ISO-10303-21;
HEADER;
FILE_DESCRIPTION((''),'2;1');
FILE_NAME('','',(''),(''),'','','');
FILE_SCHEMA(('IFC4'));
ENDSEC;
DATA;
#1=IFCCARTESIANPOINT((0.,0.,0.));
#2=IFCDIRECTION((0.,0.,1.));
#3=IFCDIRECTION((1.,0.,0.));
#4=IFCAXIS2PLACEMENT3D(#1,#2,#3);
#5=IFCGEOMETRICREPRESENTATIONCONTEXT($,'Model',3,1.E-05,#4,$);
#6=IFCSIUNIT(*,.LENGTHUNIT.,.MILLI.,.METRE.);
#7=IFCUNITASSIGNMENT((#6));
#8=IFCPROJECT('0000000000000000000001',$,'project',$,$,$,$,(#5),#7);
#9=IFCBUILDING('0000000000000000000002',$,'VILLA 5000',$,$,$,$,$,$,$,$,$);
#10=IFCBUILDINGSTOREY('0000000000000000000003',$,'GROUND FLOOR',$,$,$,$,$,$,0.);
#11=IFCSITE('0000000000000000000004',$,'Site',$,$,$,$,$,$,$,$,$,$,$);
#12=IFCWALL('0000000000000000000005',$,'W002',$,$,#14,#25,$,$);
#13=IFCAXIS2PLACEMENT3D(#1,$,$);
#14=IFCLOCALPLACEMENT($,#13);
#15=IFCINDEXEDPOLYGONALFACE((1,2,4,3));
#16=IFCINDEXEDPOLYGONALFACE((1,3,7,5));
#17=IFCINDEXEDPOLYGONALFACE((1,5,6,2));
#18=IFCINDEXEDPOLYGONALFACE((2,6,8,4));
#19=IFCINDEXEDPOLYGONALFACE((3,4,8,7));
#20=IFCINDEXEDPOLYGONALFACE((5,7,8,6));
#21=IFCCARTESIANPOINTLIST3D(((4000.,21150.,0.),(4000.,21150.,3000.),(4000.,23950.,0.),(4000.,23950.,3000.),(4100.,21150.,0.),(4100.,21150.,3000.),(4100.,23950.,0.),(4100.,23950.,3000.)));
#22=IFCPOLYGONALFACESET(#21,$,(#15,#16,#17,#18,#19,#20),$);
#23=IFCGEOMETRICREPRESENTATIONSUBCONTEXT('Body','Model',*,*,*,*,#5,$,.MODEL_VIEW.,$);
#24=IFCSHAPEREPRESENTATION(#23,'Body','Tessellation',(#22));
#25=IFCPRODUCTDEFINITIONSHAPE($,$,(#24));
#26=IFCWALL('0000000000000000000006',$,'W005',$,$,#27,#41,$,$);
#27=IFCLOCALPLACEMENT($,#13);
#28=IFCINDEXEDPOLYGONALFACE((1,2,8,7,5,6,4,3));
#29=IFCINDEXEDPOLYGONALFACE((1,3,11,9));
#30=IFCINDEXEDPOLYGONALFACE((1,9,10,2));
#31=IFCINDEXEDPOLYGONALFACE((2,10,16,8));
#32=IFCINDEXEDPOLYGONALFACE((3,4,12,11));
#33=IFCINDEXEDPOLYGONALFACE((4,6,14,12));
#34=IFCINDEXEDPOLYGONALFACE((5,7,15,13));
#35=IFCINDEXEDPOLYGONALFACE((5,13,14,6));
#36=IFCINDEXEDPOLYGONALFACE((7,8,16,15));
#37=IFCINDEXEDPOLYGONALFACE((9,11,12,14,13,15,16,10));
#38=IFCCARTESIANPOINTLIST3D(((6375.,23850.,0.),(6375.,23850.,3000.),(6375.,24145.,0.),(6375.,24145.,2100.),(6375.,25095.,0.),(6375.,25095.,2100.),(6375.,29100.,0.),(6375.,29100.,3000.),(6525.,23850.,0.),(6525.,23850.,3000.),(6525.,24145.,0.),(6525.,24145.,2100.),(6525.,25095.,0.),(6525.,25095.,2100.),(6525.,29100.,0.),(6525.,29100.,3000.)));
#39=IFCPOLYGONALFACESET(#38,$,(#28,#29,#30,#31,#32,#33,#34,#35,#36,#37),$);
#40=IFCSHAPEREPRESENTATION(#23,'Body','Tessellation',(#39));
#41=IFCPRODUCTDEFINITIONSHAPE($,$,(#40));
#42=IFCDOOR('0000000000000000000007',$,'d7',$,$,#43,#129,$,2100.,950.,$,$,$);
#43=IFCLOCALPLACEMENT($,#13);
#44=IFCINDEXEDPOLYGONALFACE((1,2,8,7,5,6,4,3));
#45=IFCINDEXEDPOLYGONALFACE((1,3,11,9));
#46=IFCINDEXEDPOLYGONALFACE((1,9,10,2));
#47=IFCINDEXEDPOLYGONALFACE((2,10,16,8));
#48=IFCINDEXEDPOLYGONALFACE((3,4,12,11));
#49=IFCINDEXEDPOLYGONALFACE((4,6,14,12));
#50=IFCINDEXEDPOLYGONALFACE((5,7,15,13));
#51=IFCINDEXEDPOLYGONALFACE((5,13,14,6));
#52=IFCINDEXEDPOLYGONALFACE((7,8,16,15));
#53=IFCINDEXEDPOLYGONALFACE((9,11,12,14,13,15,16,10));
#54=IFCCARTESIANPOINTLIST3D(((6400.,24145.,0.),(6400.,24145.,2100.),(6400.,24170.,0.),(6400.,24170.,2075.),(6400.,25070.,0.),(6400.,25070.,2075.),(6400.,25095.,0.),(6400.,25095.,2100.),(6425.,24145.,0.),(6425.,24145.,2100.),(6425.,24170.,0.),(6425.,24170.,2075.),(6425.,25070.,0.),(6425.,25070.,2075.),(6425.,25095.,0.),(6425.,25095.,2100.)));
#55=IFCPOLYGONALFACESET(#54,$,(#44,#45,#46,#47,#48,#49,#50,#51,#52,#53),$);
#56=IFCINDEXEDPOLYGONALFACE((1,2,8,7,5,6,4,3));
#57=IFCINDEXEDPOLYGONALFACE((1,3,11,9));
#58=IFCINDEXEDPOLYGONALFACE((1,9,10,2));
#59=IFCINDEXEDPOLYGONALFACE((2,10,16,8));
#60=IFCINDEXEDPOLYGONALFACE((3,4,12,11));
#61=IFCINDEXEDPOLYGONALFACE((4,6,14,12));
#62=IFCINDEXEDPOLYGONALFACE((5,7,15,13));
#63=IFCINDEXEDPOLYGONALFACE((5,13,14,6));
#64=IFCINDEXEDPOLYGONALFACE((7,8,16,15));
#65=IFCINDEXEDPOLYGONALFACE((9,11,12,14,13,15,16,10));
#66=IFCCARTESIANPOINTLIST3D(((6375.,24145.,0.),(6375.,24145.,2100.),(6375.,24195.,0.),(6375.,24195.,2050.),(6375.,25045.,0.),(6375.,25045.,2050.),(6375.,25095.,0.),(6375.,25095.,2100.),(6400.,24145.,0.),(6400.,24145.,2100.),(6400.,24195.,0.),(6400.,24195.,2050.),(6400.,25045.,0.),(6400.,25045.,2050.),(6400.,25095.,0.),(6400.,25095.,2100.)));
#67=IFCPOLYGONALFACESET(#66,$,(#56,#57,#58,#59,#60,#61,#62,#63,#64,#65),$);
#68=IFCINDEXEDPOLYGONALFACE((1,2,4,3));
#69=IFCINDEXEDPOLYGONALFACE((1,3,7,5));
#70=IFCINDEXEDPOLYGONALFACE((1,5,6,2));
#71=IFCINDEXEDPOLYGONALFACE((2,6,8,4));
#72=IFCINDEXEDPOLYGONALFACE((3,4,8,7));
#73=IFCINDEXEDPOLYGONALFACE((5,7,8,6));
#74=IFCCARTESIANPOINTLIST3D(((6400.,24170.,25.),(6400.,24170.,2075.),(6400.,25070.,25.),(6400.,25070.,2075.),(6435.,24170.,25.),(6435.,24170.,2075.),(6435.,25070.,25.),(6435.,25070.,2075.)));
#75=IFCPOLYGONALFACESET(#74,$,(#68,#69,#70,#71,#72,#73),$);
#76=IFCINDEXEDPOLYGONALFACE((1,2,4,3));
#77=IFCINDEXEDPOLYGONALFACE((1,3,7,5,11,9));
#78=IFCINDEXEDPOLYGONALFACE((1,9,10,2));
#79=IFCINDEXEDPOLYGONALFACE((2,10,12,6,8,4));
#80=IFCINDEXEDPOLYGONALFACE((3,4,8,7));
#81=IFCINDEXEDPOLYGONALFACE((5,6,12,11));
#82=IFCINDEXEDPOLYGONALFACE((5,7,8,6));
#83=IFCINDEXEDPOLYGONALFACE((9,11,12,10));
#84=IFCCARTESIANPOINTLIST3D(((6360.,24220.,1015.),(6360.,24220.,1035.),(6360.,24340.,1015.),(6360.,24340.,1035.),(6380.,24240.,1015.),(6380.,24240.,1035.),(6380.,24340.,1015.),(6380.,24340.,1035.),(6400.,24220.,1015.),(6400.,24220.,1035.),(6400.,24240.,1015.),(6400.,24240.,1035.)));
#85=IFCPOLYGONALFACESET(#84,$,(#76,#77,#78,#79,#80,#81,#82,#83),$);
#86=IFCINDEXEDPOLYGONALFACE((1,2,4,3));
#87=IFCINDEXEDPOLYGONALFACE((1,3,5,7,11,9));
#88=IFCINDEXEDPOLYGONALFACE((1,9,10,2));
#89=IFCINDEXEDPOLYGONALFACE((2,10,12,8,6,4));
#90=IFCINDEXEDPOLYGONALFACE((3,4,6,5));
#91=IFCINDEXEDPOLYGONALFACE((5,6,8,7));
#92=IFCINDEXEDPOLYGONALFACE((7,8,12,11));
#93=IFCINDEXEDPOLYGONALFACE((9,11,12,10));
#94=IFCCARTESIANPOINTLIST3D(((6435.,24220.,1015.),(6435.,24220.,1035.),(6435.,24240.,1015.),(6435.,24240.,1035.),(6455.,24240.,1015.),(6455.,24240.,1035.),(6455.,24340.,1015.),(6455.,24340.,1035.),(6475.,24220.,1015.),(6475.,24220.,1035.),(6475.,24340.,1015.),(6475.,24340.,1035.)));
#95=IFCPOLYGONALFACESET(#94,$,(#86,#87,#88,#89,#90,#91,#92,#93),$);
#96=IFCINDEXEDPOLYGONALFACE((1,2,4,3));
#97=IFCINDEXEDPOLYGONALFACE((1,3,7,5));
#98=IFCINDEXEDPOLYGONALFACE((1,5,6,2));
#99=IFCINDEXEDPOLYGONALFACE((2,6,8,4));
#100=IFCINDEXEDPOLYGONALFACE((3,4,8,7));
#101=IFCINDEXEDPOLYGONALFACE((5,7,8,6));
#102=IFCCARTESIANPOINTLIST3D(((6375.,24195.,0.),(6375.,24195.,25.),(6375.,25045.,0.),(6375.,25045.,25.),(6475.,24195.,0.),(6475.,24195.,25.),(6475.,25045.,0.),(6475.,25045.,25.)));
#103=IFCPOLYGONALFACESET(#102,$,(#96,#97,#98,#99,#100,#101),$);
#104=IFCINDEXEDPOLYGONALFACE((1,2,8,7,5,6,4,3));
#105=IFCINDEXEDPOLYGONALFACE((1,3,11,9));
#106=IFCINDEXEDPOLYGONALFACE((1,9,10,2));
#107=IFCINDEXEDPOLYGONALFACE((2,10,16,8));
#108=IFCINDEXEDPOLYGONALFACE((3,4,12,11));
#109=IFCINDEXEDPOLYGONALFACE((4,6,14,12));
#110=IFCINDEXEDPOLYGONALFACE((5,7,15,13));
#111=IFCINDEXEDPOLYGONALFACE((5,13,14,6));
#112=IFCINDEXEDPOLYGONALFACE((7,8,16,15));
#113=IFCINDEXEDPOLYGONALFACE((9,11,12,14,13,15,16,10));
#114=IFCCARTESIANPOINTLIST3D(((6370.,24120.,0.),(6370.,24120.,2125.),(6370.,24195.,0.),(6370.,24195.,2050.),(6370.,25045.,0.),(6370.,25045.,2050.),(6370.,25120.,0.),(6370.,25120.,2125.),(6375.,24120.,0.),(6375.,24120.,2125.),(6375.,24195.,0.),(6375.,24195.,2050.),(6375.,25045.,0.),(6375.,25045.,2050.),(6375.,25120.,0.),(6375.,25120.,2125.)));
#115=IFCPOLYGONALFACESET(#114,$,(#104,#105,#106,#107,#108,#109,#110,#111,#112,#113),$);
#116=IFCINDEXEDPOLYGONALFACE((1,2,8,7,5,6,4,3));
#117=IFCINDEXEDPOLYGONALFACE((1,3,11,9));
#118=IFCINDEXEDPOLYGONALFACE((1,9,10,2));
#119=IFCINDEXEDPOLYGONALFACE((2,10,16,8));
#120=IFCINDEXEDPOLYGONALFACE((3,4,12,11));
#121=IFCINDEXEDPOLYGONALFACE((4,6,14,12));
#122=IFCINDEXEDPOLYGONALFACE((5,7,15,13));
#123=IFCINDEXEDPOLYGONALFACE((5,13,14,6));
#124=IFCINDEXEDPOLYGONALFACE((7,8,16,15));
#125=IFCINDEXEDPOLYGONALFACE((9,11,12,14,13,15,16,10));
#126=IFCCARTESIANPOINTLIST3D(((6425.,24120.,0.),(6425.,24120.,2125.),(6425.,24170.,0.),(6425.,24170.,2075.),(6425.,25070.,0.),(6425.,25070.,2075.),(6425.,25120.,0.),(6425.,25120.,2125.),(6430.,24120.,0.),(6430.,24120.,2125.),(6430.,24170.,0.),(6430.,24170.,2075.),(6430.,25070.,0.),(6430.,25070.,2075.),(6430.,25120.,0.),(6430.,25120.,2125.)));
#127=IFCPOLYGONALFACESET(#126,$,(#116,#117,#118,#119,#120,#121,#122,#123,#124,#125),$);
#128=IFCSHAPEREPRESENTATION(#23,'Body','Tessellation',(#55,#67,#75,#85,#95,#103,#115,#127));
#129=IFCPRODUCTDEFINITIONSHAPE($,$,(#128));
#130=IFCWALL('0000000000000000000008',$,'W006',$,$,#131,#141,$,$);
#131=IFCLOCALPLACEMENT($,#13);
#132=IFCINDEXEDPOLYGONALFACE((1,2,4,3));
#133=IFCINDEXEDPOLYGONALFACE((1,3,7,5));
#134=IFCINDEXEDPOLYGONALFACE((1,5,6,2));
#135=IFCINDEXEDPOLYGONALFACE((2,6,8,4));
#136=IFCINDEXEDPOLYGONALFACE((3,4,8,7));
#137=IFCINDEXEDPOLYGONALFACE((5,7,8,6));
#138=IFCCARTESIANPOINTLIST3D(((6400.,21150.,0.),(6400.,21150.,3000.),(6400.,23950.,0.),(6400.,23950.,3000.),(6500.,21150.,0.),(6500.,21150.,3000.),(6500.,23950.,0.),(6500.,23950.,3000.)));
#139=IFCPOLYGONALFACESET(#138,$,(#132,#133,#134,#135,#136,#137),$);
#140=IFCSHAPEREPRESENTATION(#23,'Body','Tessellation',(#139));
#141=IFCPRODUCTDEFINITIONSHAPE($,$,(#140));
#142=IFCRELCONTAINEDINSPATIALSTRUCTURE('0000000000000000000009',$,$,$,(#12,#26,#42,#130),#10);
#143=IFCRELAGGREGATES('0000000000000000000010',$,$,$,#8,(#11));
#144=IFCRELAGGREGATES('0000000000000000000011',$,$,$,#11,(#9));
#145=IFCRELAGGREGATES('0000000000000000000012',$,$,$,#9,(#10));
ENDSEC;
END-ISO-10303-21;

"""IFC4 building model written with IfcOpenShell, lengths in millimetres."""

from ifc_helpers import new_model, si_unit, frame, origin_with_axes, place, context, subcontext, project, spatial, line, indexed_curve, outline, extrude, element, fill, save


model = new_model("IFC4")

# Units and contexts
model_context = context("Model", 3, precision=1e-05, world=origin_with_axes())
body_context = subcontext(model_context, "Body", "Model", "MODEL_VIEW")
ifc_project = project(units=[si_unit("LENGTHUNIT", "METRE", prefix="MILLI")], contexts=[model_context])

# Site, building, storey
site = spatial("IfcSite", under=ifc_project, Name="Site")
building = spatial("IfcBuilding", under=site, Name="VILLA 5000")
storey = spatial("IfcBuildingStorey", under=building, Name="GROUND FLOOR", Elevation=0.0)

# Wall
wall_1_placement = place(None, frame((4050.0, 23950.0, 0.0), z_axis=(0.0, 0.0, 1.0), x_axis=(0.0, -1.0, 0.0)))
element("IfcWall", 1, at=wall_1_placement, inside=storey, Name="W002", context=body_context, shape_type="SweptSolid", body=[
    extrude(outline(indexed_curve([(0.0, 0.0), (0.0, 100.0), (2800.0, 100.0), (2800.0, 0.0), (0.0, 0.0)], self_intersect=False)), frame((0.0, -50.0, 0.0), z_axis=(0.0, 0.0, 1.0), x_axis=(1.0, 0.0, 0.0)), (0.0, 0.0, 1.0), 3000.0),
])

# Wall, opening, door
wall_2_placement = place(None, frame((6450.0, 29100.0, 0.0), z_axis=(0.0, 0.0, 1.0), x_axis=(0.0, -1.0, 0.0)))
wall_2 = element("IfcWall", 2, at=wall_2_placement, inside=storey, Name="W005", context=body_context, shape_type="SweptSolid", body=[
    extrude(outline(indexed_curve([(0.0, 0.0), (0.0, 150.0), (5250.0, 150.0), (5250.0, 0.0), (0.0, 0.0)], self_intersect=False)), frame((0.0, -75.0, 0.0), z_axis=(0.0, 0.0, 1.0), x_axis=(1.0, 0.0, 0.0)), (0.0, 0.0, 1.0), 3000.0),
])
opening_1_placement = place(wall_2_placement, frame((4005.0, 0.0, 0.0), z_axis=(0.0, 0.0, 1.0), x_axis=(1.0, 0.0, 0.0)))
opening_1 = element("IfcOpeningElement", 3, at=opening_1_placement, cuts=wall_2, context=body_context, shape_type="SweptSolid", body=[
    extrude(outline(indexed_curve([(0.0, 0.0), (0.0, 250.0), (950.0, 250.0), (950.0, 0.0), (0.0, 0.0)], self_intersect=False)), frame((0.0, -125.0, 0.0), z_axis=(0.0, 0.0, 1.0), x_axis=(1.0, 0.0, 0.0)), (0.0, 0.0, 1.0), 2100.0),
])
door_1_placement = place(None, frame((6375.0, 25095.0, 0.0), z_axis=(0.0, 0.0, 1.0), x_axis=(0.0, -1.0, 0.0)))
door_1 = element("IfcDoor", 4, at=door_1_placement, inside=storey, Name="d7", OverallHeight=2100.0, OverallWidth=950.0, context=body_context, shape_type="SweptSolid", body=[
    extrude(outline(indexed_curve([(0.0, 0.0), (0.0, 2100.0), (950.0, 2100.0), (950.0, 0.0), (925.0, 0.0), (925.0, 2075.0), (25.0, 2075.0), (25.0, 0.0)], segments=[line(1, 2, 3, 4, 5, 6, 7, 8, 1)])), frame((0.0, 25.0, 0.0), z_axis=(0.0, -1.0, 0.0), x_axis=(1.0, 0.0, 0.0)), (0.0, 0.0, -1.0), 25.0),
    extrude(outline(indexed_curve([(0.0, 0.0), (0.0, 2100.0), (950.0, 2100.0), (950.0, 0.0), (900.0, 0.0), (900.0, 2050.0), (50.0, 2050.0), (50.0, 0.0)], segments=[line(1, 2, 3, 4, 5, 6, 7, 8, 1)])), frame((0.0, 0.0, 0.0), z_axis=(0.0, -1.0, 0.0), x_axis=(1.0, 0.0, 0.0)), (0.0, 0.0, -1.0), 25.0),
    extrude(outline(indexed_curve([(0.0, 0.0), (900.0, 0.0), (900.0, 35.0), (0.0, 35.0)], segments=[line(1, 2, 3, 4, 1)])), frame((25.0, 25.0, 25.0), z_axis=(0.0, 0.0, 1.0), x_axis=(1.0, 0.0, 0.0)), (0.0, 0.0, 1.0), 2050.0),
    extrude(outline(indexed_curve([(0.0, 0.0), (0.0, -40.0), (-120.0, -40.0), (-120.0, -20.0), (-20.0, -20.0), (-20.0, 0.0)], segments=[line(1, 2, 3, 4, 5, 6, 1)])), frame((875.0, 25.0, 1015.0), z_axis=(0.0, 0.0, 1.0), x_axis=(1.0, 0.0, 0.0)), (0.0, 0.0, 1.0), 20.0),
    extrude(outline(indexed_curve([(0.0, 0.0), (0.0, 40.0), (-120.0, 40.0), (-120.0, 20.0), (-20.0, 20.0), (-20.0, 0.0)], segments=[line(1, 2, 3, 4, 5, 6, 1)])), frame((875.0, 60.0, 1015.0), z_axis=(0.0, 0.0, 1.0), x_axis=(1.0, 0.0, 0.0)), (0.0, 0.0, 1.0), 20.0),
    extrude(outline(indexed_curve([(0.0, 0.0), (850.0, 0.0), (850.0, 100.0), (0.0, 100.0)], segments=[line(1, 2, 3, 4, 1)])), frame((50.0, 0.0, 0.0), z_axis=(0.0, 0.0, 1.0), x_axis=(1.0, 0.0, 0.0)), (0.0, 0.0, 1.0), 25.0),
    extrude(outline(indexed_curve([(0.0, 0.0), (0.0, 2125.0), (1000.0, 2125.0), (1000.0, 0.0), (925.0, 0.0), (925.0, 2050.0), (75.0, 2050.0), (75.0, 0.0)], segments=[line(1, 2, 3, 4, 5, 6, 7, 8, 1)])), frame((-25.0, -5.0, 0.0), z_axis=(0.0, -1.0, 0.0), x_axis=(1.0, 0.0, 0.0)), (0.0, 0.0, -1.0), 5.0),
    extrude(outline(indexed_curve([(0.0, 0.0), (0.0, 2125.0), (1000.0, 2125.0), (1000.0, 0.0), (950.0, 0.0), (950.0, 2075.0), (50.0, 2075.0), (50.0, 0.0)], segments=[line(1, 2, 3, 4, 5, 6, 7, 8, 1)])), frame((-25.0, 50.0, 0.0), z_axis=(0.0, -1.0, 0.0), x_axis=(1.0, 0.0, 0.0)), (0.0, 0.0, -1.0), 5.0),
])
fill(opening_1, door_1)

# Wall
wall_3_placement = place(None, frame((6450.0, 23950.0, 0.0), z_axis=(0.0, 0.0, 1.0), x_axis=(0.0, -1.0, 0.0)))
element("IfcWall", 5, at=wall_3_placement, inside=storey, Name="W006", context=body_context, shape_type="SweptSolid", body=[
    extrude(outline(indexed_curve([(0.0, 0.0), (0.0, 100.0), (2800.0, 100.0), (2800.0, 0.0), (0.0, 0.0)], self_intersect=False)), frame((0.0, -50.0, 0.0), z_axis=(0.0, 0.0, 1.0), x_axis=(1.0, 0.0, 0.0)), (0.0, 0.0, 1.0), 3000.0),
])

save(model, "model.ifc")
